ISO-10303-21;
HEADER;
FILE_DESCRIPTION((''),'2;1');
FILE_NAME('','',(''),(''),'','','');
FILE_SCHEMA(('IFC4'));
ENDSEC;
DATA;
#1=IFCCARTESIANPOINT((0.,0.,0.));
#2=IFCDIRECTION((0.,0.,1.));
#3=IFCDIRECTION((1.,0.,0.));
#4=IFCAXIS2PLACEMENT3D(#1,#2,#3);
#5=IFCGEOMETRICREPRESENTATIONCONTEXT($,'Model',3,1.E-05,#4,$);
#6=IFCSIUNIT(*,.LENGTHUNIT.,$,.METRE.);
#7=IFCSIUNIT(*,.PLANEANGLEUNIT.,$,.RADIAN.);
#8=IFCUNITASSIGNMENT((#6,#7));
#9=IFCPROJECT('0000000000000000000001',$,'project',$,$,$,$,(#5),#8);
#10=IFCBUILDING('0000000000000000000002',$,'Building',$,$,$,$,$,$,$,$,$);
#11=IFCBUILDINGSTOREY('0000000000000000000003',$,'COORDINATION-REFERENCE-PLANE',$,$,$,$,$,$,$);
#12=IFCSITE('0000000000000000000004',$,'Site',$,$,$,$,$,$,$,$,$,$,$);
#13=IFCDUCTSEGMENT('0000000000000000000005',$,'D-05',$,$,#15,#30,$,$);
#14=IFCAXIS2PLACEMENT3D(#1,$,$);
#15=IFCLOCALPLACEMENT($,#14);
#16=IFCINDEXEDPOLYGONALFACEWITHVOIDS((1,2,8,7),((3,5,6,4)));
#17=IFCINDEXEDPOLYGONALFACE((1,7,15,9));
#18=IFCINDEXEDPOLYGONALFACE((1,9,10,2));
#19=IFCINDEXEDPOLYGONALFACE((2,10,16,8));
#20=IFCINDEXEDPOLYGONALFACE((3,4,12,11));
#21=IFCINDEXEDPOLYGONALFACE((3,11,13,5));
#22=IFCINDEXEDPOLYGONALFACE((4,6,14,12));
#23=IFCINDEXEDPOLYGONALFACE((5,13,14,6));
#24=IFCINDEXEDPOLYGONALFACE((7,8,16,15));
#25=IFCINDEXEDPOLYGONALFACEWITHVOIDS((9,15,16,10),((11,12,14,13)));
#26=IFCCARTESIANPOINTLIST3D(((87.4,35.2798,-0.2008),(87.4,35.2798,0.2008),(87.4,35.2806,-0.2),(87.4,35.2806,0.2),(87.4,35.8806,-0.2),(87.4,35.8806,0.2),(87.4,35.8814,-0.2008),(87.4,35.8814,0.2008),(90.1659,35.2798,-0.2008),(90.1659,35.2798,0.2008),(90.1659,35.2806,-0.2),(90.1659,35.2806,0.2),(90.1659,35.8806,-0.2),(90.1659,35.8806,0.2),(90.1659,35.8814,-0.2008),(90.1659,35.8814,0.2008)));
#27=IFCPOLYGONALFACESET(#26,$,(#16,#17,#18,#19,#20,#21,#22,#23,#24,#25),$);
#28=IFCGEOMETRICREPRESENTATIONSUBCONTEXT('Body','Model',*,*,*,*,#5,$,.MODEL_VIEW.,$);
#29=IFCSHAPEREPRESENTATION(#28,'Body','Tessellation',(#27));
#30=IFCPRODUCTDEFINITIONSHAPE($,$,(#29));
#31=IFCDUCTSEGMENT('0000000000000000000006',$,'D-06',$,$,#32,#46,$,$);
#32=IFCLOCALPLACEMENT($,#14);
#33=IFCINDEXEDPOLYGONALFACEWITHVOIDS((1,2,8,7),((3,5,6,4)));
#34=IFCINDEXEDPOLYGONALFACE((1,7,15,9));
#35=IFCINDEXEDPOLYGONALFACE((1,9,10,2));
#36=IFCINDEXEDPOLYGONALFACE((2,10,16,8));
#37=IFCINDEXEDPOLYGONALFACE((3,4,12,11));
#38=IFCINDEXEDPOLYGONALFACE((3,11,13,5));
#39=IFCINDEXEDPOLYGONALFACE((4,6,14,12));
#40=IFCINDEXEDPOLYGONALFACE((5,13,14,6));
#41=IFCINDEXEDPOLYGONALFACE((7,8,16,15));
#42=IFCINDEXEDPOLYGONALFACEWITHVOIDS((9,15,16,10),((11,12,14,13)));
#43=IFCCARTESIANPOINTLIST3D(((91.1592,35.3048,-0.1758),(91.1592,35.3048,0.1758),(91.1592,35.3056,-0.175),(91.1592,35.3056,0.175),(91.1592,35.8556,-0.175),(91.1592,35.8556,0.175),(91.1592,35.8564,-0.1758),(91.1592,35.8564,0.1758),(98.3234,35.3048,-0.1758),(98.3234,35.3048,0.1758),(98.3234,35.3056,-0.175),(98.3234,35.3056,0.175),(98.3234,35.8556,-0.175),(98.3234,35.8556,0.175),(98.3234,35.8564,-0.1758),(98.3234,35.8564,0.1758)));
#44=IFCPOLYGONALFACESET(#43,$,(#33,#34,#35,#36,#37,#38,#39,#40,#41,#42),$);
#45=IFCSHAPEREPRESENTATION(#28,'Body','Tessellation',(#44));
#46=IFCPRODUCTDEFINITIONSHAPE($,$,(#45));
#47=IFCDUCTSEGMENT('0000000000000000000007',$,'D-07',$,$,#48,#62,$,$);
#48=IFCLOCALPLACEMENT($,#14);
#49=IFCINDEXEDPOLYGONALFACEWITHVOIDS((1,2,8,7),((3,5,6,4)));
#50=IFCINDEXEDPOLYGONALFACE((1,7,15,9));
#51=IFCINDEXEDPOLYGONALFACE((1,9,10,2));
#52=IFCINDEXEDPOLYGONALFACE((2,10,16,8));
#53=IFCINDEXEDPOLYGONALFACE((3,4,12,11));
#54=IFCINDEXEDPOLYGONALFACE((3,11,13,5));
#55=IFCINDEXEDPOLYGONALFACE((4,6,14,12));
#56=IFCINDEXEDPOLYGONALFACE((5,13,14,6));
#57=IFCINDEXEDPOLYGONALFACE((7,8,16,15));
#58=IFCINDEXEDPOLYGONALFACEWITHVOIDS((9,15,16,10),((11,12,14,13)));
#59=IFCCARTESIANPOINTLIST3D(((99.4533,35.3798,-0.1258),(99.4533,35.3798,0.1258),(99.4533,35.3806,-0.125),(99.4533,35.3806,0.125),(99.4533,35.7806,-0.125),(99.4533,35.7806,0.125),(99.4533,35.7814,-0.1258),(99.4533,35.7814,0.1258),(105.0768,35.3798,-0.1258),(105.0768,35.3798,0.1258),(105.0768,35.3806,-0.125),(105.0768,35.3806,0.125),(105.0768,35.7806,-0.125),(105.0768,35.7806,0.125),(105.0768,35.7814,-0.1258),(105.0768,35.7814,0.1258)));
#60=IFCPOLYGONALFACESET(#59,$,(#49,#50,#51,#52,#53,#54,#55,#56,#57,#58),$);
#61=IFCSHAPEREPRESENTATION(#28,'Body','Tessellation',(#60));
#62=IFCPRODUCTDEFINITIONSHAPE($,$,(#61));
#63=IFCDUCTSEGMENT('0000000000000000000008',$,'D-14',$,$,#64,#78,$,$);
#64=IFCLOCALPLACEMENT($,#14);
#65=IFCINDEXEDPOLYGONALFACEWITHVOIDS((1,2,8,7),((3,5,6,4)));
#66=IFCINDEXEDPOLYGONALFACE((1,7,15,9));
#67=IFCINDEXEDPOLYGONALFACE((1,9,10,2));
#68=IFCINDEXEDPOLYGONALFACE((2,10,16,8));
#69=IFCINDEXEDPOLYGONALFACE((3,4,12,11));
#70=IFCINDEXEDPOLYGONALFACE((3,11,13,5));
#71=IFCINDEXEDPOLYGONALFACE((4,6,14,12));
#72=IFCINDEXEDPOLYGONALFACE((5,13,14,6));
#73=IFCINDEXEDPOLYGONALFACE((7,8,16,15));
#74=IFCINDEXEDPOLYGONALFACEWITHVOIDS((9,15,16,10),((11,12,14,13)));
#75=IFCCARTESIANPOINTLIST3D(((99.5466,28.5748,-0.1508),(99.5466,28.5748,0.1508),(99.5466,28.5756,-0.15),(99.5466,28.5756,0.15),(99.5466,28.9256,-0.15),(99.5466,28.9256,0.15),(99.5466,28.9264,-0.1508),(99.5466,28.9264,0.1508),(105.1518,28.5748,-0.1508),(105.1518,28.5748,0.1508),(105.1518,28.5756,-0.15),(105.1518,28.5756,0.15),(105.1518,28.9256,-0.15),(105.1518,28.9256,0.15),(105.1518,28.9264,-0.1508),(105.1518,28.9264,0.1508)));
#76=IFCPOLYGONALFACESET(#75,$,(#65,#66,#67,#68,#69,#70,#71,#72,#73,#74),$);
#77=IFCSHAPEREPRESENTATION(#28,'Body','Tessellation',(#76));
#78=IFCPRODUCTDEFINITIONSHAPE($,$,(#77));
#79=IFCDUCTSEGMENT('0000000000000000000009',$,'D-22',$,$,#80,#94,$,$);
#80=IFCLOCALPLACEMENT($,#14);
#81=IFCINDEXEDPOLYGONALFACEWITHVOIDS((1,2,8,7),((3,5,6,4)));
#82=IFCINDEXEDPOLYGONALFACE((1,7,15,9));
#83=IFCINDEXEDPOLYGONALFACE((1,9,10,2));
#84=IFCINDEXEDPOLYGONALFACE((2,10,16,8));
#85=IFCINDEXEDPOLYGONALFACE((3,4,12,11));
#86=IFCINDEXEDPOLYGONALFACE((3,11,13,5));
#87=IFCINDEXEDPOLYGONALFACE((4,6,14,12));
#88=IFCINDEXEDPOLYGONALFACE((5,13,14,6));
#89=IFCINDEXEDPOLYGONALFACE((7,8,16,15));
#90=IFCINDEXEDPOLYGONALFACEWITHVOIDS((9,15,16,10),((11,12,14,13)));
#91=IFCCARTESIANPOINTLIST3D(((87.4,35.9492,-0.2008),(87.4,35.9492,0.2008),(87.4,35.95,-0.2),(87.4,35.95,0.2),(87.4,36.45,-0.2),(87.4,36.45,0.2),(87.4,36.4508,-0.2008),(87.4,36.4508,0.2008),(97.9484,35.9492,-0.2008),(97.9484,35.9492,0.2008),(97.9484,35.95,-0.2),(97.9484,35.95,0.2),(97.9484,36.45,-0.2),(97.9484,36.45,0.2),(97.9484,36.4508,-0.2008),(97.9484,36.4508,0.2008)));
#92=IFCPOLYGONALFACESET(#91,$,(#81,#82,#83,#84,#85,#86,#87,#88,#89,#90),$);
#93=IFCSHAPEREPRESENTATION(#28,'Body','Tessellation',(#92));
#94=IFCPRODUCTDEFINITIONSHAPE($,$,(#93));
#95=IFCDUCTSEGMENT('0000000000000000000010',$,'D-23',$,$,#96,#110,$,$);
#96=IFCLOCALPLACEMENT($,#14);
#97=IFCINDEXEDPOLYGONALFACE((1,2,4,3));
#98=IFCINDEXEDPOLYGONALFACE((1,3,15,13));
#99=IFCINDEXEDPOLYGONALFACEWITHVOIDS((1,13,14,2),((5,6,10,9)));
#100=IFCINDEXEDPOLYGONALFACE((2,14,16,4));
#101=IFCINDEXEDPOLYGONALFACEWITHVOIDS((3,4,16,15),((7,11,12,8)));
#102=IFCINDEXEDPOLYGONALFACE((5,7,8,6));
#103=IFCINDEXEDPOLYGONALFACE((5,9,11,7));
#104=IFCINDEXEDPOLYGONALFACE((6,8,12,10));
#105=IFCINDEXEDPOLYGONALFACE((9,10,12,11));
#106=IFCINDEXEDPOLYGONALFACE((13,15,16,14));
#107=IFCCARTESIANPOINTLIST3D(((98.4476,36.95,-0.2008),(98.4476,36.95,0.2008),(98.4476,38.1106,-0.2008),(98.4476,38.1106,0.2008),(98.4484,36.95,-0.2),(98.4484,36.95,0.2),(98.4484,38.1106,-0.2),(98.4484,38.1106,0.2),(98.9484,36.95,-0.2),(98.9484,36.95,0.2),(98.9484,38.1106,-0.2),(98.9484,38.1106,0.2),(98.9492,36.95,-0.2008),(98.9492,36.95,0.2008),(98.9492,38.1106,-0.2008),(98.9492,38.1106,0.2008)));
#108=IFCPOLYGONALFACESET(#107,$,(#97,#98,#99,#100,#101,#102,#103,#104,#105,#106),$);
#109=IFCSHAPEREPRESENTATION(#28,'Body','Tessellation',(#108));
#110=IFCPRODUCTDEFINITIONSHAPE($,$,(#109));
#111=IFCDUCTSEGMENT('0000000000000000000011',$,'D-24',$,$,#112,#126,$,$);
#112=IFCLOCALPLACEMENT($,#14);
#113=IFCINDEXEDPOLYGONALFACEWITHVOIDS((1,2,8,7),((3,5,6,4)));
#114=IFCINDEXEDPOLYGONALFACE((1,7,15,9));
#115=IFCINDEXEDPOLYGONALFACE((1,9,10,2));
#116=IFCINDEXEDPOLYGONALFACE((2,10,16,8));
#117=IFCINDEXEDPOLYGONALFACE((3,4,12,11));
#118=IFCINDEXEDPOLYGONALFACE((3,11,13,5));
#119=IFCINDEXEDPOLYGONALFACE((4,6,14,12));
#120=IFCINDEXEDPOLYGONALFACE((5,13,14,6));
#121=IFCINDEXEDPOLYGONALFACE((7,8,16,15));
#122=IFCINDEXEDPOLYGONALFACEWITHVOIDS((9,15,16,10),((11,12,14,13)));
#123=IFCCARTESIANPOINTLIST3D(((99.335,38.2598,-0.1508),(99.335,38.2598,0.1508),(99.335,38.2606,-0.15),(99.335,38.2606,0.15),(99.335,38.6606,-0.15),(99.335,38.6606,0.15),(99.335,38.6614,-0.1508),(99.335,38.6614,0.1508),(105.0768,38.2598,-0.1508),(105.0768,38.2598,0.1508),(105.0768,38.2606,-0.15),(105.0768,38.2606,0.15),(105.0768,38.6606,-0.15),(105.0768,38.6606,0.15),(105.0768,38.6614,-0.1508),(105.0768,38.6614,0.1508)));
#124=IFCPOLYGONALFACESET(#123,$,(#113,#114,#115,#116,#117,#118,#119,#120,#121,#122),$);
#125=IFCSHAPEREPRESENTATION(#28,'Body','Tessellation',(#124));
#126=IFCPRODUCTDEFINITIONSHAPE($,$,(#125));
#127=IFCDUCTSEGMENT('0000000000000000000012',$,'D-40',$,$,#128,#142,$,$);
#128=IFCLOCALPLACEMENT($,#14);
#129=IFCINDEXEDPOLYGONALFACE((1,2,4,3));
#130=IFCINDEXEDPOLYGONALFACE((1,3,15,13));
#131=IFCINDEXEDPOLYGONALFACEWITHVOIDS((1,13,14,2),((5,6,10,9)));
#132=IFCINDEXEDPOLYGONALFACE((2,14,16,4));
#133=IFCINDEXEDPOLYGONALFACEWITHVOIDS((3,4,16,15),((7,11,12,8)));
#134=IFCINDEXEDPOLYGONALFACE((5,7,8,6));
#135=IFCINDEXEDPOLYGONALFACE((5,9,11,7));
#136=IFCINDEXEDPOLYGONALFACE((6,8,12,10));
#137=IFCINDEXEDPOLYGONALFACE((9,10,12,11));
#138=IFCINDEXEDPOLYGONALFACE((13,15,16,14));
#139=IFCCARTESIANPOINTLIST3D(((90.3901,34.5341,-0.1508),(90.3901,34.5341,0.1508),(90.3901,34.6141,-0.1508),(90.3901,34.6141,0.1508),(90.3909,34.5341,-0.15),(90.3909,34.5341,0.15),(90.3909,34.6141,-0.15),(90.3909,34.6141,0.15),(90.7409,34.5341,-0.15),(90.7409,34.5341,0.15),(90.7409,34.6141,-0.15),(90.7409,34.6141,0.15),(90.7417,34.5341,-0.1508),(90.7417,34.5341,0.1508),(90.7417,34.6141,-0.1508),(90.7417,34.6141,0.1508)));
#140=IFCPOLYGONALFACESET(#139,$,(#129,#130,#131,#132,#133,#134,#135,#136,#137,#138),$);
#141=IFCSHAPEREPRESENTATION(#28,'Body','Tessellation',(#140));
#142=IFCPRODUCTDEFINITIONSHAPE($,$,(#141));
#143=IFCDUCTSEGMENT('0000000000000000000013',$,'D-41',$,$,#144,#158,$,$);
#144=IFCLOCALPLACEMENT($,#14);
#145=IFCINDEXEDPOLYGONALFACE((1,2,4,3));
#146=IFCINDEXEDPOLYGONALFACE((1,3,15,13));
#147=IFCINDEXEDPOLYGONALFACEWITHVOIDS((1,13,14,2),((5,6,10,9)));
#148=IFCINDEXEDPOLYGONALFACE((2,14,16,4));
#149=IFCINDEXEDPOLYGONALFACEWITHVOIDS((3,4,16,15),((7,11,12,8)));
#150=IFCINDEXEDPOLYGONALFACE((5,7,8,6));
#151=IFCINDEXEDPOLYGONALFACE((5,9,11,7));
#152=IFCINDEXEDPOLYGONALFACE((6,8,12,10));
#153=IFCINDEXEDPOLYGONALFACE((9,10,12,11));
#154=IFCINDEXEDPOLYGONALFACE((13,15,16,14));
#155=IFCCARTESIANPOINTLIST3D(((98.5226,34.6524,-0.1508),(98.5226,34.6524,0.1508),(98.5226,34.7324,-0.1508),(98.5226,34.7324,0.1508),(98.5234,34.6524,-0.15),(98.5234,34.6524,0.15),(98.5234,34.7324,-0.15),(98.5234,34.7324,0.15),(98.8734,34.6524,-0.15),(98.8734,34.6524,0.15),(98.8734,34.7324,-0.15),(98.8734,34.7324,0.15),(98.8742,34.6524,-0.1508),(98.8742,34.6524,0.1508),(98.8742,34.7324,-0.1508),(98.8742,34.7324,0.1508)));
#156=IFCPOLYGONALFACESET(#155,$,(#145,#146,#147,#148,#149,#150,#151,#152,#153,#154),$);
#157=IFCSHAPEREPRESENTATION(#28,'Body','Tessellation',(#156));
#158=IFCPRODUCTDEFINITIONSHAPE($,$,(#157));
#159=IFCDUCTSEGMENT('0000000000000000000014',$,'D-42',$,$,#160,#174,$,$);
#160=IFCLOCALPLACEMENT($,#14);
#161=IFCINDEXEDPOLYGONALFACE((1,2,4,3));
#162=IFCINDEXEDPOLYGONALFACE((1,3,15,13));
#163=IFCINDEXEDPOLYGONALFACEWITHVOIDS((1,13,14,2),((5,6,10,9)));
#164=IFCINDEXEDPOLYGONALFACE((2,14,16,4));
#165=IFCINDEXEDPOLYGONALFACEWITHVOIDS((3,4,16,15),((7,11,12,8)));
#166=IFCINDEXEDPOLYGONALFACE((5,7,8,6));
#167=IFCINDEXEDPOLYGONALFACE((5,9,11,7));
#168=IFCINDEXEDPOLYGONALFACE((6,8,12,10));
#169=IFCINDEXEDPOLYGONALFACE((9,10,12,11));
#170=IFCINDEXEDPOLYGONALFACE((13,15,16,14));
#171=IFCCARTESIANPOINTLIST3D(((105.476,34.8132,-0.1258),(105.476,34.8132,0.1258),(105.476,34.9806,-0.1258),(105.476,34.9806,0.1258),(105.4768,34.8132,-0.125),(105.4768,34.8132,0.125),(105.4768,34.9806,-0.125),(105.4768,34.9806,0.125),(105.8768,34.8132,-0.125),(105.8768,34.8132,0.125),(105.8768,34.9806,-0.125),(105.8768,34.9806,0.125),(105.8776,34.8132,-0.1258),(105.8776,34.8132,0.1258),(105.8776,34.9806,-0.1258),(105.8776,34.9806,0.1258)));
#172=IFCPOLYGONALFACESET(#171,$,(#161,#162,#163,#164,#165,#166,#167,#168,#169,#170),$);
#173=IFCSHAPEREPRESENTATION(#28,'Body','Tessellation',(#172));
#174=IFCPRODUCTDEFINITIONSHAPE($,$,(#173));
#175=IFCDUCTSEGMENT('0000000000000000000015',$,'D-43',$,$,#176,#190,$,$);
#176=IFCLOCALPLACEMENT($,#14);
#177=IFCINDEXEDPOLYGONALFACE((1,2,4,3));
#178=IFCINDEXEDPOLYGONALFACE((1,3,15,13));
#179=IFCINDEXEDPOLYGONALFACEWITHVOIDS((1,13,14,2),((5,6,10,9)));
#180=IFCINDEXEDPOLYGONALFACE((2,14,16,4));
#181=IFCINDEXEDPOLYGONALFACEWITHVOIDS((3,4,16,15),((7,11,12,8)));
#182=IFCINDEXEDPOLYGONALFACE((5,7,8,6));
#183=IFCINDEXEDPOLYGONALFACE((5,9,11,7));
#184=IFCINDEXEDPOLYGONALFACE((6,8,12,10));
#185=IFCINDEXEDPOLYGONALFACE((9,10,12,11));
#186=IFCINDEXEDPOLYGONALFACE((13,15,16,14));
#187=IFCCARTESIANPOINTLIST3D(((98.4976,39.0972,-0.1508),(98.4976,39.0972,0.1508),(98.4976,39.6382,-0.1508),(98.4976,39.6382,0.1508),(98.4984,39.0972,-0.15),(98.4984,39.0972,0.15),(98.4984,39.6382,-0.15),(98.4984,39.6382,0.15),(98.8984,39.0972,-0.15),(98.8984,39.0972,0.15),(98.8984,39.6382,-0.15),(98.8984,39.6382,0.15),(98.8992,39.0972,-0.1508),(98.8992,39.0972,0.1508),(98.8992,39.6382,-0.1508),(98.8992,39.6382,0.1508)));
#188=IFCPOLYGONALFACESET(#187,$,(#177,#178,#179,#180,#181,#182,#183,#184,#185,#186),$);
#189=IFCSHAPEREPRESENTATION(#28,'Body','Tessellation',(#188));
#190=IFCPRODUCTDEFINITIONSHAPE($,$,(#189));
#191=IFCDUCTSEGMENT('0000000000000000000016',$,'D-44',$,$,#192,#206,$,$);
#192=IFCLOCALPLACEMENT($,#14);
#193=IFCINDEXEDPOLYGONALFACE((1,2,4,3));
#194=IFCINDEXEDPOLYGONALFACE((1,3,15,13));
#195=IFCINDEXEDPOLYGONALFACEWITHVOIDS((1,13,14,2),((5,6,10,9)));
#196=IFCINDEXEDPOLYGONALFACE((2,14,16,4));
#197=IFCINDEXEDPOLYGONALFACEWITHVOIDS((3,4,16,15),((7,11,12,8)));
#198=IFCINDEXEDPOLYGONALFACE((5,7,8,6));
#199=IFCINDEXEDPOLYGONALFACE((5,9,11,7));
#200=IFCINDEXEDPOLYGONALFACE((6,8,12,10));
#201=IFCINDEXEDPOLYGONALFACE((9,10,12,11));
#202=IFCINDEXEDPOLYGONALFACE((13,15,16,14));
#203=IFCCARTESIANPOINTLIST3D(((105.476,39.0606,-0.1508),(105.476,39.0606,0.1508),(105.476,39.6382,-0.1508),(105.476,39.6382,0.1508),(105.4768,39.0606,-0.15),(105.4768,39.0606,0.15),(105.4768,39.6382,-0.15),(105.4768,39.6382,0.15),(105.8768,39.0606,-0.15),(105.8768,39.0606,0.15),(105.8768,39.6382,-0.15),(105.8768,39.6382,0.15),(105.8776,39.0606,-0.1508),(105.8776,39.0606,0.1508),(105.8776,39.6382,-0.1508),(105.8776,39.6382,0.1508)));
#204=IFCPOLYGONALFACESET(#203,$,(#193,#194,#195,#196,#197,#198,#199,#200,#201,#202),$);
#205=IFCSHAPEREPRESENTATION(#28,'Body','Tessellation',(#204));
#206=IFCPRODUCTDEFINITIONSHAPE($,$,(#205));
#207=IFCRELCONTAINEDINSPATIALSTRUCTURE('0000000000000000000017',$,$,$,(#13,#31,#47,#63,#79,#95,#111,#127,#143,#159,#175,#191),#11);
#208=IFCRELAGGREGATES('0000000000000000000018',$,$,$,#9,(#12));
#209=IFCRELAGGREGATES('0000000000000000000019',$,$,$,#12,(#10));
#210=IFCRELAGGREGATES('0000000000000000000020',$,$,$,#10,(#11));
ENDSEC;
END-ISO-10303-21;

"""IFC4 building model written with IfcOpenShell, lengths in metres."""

from ifc_helpers import new_model, si_unit, frame, origin, origin_with_axes, place, context, subcontext, project, spatial, hollow_rectangle, extrude, element, save


model = new_model("IFC4")

# Units and contexts
model_context = context("Model", 3, precision=1e-05, world=origin_with_axes())
body_context_1 = subcontext(model_context, "Body", "Model", "MODEL_VIEW")
ifc_project = project(units=[si_unit("LENGTHUNIT", "METRE"), si_unit("PLANEANGLEUNIT", "RADIAN")], contexts=[model_context])

# Site, building, storey
site = spatial("IfcSite", under=ifc_project, Name="Site")
building = spatial("IfcBuilding", under=site, Name="Building")
storey = spatial("IfcBuildingStorey", under=building, Name="COORDINATION-REFERENCE-PLANE")

# Duct segments
duct_segment_1_placement = place(None, frame((87.4, 35.5806, 0.0), z_axis=(1.0, 0.0, 0.0), x_axis=(0.0, 1.0, 0.0)))
element("IfcDuctSegment", 1, at=duct_segment_1_placement, inside=storey, Name="D-05", context=body_context_1, shape_type="SweptSolid", body=[
    extrude(hollow_rectangle(XDim=0.6016, YDim=0.4016, WallThickness=0.0008), origin(), (0.0, 0.0, 1.0), 2.7659),
])
duct_segment_2_placement = place(None, frame((91.1592, 35.5806, 0.0), z_axis=(1.0, 0.0, 0.0), x_axis=(0.0, 1.0, 0.0)))
element("IfcDuctSegment", 2, at=duct_segment_2_placement, inside=storey, Name="D-06", context=body_context_1, shape_type="SweptSolid", body=[
    extrude(hollow_rectangle(XDim=0.5516, YDim=0.3516, WallThickness=0.0008), origin(), (0.0, 0.0, 1.0), 7.1642),
])
duct_segment_3_placement = place(None, frame((99.4533, 35.5806, 0.0), z_axis=(1.0, 0.0, 0.0), x_axis=(0.0, 1.0, 0.0)))
element("IfcDuctSegment", 3, at=duct_segment_3_placement, inside=storey, Name="D-07", context=body_context_1, shape_type="SweptSolid", body=[
    extrude(hollow_rectangle(XDim=0.4016, YDim=0.2516, WallThickness=0.0008), origin(), (0.0, 0.0, 1.0), 5.6234),
])
duct_segment_4_placement = place(None, frame((99.5466, 28.7506, 0.0), z_axis=(1.0, 0.0, 0.0), x_axis=(0.0, 1.0, 0.0)))
element("IfcDuctSegment", 4, at=duct_segment_4_placement, inside=storey, Name="D-14", context=body_context_1, shape_type="SweptSolid", body=[
    extrude(hollow_rectangle(XDim=0.3516, YDim=0.3016, WallThickness=0.0008), origin(), (0.0, 0.0, 1.0), 5.6051),
])
duct_segment_5_placement = place(None, frame((87.4, 36.2, 0.0), z_axis=(1.0, 0.0, 0.0), x_axis=(0.0, 1.0, 0.0)))
element("IfcDuctSegment", 5, at=duct_segment_5_placement, inside=storey, Name="D-22", context=body_context_1, shape_type="SweptSolid", body=[
    extrude(hollow_rectangle(XDim=0.5016, YDim=0.4016, WallThickness=0.0008), origin(), (0.0, 0.0, 1.0), 10.5484),
])
duct_segment_6_placement = place(None, frame((98.6984, 36.95, 0.0), z_axis=(0.0, 1.0, 0.0), x_axis=(1.0, 0.0, 0.0)))
element("IfcDuctSegment", 6, at=duct_segment_6_placement, inside=storey, Name="D-23", context=body_context_1, shape_type="SweptSolid", body=[
    extrude(hollow_rectangle(XDim=0.5016, YDim=0.4016, WallThickness=0.0008), origin(), (0.0, 0.0, 1.0), 1.1606),
])
duct_segment_7_placement = place(None, frame((99.335, 38.4606, 0.0), z_axis=(1.0, 0.0, 0.0), x_axis=(0.0, 1.0, 0.0)))
element("IfcDuctSegment", 7, at=duct_segment_7_placement, inside=storey, Name="D-24", context=body_context_1, shape_type="SweptSolid", body=[
    extrude(hollow_rectangle(XDim=0.4016, YDim=0.3016, WallThickness=0.0008), origin(), (0.0, 0.0, 1.0), 5.7417),
])
for number, where, z_axis, x_axis, name in (
    (8, (90.5659, 34.5341, 0.0), (0.0, 1.0, 0.0), (1.0, 0.0, 0.0), "D-40"),
    (9, (98.6984, 34.6524, 0.0), (0.0, 1.0, 0.0), (1.0, 0.0, 0.0), "D-41"),
):
    element("IfcDuctSegment", number, at=place(None, frame(where, z_axis=z_axis, x_axis=x_axis)), inside=storey, Name=name, context=body_context_1, shape_type="SweptSolid", body=[
        extrude(hollow_rectangle(XDim=0.3516, YDim=0.3016, WallThickness=0.0008), origin(), (0.0, 0.0, 1.0), 0.08),
    ])
duct_segment_8_placement = place(None, frame((105.6768, 34.8132, 0.0), z_axis=(0.0, 1.0, 0.0), x_axis=(1.0, 0.0, 0.0)))
element("IfcDuctSegment", 10, at=duct_segment_8_placement, inside=storey, Name="D-42", context=body_context_1, shape_type="SweptSolid", body=[
    extrude(hollow_rectangle(XDim=0.4016, YDim=0.2516, WallThickness=0.0008), origin(), (0.0, 0.0, 1.0), 0.1673),
])
duct_segment_9_placement = place(None, frame((98.6984, 39.0972, 0.0), z_axis=(0.0, 1.0, 0.0), x_axis=(1.0, 0.0, 0.0)))
element("IfcDuctSegment", 11, at=duct_segment_9_placement, inside=storey, Name="D-43", context=body_context_1, shape_type="SweptSolid", body=[
    extrude(hollow_rectangle(XDim=0.4016, YDim=0.3016, WallThickness=0.0008), origin(), (0.0, 0.0, 1.0), 0.541),
])
duct_segment_10_placement = place(None, frame((105.6768, 39.0606, 0.0), z_axis=(0.0, 1.0, 0.0), x_axis=(1.0, 0.0, 0.0)))
element("IfcDuctSegment", 12, at=duct_segment_10_placement, inside=storey, Name="D-44", context=body_context_1, shape_type="SweptSolid", body=[
    extrude(hollow_rectangle(XDim=0.4016, YDim=0.3016, WallThickness=0.0008), origin(), (0.0, 0.0, 1.0), 0.5776),
])

save(model, "model.ifc")
